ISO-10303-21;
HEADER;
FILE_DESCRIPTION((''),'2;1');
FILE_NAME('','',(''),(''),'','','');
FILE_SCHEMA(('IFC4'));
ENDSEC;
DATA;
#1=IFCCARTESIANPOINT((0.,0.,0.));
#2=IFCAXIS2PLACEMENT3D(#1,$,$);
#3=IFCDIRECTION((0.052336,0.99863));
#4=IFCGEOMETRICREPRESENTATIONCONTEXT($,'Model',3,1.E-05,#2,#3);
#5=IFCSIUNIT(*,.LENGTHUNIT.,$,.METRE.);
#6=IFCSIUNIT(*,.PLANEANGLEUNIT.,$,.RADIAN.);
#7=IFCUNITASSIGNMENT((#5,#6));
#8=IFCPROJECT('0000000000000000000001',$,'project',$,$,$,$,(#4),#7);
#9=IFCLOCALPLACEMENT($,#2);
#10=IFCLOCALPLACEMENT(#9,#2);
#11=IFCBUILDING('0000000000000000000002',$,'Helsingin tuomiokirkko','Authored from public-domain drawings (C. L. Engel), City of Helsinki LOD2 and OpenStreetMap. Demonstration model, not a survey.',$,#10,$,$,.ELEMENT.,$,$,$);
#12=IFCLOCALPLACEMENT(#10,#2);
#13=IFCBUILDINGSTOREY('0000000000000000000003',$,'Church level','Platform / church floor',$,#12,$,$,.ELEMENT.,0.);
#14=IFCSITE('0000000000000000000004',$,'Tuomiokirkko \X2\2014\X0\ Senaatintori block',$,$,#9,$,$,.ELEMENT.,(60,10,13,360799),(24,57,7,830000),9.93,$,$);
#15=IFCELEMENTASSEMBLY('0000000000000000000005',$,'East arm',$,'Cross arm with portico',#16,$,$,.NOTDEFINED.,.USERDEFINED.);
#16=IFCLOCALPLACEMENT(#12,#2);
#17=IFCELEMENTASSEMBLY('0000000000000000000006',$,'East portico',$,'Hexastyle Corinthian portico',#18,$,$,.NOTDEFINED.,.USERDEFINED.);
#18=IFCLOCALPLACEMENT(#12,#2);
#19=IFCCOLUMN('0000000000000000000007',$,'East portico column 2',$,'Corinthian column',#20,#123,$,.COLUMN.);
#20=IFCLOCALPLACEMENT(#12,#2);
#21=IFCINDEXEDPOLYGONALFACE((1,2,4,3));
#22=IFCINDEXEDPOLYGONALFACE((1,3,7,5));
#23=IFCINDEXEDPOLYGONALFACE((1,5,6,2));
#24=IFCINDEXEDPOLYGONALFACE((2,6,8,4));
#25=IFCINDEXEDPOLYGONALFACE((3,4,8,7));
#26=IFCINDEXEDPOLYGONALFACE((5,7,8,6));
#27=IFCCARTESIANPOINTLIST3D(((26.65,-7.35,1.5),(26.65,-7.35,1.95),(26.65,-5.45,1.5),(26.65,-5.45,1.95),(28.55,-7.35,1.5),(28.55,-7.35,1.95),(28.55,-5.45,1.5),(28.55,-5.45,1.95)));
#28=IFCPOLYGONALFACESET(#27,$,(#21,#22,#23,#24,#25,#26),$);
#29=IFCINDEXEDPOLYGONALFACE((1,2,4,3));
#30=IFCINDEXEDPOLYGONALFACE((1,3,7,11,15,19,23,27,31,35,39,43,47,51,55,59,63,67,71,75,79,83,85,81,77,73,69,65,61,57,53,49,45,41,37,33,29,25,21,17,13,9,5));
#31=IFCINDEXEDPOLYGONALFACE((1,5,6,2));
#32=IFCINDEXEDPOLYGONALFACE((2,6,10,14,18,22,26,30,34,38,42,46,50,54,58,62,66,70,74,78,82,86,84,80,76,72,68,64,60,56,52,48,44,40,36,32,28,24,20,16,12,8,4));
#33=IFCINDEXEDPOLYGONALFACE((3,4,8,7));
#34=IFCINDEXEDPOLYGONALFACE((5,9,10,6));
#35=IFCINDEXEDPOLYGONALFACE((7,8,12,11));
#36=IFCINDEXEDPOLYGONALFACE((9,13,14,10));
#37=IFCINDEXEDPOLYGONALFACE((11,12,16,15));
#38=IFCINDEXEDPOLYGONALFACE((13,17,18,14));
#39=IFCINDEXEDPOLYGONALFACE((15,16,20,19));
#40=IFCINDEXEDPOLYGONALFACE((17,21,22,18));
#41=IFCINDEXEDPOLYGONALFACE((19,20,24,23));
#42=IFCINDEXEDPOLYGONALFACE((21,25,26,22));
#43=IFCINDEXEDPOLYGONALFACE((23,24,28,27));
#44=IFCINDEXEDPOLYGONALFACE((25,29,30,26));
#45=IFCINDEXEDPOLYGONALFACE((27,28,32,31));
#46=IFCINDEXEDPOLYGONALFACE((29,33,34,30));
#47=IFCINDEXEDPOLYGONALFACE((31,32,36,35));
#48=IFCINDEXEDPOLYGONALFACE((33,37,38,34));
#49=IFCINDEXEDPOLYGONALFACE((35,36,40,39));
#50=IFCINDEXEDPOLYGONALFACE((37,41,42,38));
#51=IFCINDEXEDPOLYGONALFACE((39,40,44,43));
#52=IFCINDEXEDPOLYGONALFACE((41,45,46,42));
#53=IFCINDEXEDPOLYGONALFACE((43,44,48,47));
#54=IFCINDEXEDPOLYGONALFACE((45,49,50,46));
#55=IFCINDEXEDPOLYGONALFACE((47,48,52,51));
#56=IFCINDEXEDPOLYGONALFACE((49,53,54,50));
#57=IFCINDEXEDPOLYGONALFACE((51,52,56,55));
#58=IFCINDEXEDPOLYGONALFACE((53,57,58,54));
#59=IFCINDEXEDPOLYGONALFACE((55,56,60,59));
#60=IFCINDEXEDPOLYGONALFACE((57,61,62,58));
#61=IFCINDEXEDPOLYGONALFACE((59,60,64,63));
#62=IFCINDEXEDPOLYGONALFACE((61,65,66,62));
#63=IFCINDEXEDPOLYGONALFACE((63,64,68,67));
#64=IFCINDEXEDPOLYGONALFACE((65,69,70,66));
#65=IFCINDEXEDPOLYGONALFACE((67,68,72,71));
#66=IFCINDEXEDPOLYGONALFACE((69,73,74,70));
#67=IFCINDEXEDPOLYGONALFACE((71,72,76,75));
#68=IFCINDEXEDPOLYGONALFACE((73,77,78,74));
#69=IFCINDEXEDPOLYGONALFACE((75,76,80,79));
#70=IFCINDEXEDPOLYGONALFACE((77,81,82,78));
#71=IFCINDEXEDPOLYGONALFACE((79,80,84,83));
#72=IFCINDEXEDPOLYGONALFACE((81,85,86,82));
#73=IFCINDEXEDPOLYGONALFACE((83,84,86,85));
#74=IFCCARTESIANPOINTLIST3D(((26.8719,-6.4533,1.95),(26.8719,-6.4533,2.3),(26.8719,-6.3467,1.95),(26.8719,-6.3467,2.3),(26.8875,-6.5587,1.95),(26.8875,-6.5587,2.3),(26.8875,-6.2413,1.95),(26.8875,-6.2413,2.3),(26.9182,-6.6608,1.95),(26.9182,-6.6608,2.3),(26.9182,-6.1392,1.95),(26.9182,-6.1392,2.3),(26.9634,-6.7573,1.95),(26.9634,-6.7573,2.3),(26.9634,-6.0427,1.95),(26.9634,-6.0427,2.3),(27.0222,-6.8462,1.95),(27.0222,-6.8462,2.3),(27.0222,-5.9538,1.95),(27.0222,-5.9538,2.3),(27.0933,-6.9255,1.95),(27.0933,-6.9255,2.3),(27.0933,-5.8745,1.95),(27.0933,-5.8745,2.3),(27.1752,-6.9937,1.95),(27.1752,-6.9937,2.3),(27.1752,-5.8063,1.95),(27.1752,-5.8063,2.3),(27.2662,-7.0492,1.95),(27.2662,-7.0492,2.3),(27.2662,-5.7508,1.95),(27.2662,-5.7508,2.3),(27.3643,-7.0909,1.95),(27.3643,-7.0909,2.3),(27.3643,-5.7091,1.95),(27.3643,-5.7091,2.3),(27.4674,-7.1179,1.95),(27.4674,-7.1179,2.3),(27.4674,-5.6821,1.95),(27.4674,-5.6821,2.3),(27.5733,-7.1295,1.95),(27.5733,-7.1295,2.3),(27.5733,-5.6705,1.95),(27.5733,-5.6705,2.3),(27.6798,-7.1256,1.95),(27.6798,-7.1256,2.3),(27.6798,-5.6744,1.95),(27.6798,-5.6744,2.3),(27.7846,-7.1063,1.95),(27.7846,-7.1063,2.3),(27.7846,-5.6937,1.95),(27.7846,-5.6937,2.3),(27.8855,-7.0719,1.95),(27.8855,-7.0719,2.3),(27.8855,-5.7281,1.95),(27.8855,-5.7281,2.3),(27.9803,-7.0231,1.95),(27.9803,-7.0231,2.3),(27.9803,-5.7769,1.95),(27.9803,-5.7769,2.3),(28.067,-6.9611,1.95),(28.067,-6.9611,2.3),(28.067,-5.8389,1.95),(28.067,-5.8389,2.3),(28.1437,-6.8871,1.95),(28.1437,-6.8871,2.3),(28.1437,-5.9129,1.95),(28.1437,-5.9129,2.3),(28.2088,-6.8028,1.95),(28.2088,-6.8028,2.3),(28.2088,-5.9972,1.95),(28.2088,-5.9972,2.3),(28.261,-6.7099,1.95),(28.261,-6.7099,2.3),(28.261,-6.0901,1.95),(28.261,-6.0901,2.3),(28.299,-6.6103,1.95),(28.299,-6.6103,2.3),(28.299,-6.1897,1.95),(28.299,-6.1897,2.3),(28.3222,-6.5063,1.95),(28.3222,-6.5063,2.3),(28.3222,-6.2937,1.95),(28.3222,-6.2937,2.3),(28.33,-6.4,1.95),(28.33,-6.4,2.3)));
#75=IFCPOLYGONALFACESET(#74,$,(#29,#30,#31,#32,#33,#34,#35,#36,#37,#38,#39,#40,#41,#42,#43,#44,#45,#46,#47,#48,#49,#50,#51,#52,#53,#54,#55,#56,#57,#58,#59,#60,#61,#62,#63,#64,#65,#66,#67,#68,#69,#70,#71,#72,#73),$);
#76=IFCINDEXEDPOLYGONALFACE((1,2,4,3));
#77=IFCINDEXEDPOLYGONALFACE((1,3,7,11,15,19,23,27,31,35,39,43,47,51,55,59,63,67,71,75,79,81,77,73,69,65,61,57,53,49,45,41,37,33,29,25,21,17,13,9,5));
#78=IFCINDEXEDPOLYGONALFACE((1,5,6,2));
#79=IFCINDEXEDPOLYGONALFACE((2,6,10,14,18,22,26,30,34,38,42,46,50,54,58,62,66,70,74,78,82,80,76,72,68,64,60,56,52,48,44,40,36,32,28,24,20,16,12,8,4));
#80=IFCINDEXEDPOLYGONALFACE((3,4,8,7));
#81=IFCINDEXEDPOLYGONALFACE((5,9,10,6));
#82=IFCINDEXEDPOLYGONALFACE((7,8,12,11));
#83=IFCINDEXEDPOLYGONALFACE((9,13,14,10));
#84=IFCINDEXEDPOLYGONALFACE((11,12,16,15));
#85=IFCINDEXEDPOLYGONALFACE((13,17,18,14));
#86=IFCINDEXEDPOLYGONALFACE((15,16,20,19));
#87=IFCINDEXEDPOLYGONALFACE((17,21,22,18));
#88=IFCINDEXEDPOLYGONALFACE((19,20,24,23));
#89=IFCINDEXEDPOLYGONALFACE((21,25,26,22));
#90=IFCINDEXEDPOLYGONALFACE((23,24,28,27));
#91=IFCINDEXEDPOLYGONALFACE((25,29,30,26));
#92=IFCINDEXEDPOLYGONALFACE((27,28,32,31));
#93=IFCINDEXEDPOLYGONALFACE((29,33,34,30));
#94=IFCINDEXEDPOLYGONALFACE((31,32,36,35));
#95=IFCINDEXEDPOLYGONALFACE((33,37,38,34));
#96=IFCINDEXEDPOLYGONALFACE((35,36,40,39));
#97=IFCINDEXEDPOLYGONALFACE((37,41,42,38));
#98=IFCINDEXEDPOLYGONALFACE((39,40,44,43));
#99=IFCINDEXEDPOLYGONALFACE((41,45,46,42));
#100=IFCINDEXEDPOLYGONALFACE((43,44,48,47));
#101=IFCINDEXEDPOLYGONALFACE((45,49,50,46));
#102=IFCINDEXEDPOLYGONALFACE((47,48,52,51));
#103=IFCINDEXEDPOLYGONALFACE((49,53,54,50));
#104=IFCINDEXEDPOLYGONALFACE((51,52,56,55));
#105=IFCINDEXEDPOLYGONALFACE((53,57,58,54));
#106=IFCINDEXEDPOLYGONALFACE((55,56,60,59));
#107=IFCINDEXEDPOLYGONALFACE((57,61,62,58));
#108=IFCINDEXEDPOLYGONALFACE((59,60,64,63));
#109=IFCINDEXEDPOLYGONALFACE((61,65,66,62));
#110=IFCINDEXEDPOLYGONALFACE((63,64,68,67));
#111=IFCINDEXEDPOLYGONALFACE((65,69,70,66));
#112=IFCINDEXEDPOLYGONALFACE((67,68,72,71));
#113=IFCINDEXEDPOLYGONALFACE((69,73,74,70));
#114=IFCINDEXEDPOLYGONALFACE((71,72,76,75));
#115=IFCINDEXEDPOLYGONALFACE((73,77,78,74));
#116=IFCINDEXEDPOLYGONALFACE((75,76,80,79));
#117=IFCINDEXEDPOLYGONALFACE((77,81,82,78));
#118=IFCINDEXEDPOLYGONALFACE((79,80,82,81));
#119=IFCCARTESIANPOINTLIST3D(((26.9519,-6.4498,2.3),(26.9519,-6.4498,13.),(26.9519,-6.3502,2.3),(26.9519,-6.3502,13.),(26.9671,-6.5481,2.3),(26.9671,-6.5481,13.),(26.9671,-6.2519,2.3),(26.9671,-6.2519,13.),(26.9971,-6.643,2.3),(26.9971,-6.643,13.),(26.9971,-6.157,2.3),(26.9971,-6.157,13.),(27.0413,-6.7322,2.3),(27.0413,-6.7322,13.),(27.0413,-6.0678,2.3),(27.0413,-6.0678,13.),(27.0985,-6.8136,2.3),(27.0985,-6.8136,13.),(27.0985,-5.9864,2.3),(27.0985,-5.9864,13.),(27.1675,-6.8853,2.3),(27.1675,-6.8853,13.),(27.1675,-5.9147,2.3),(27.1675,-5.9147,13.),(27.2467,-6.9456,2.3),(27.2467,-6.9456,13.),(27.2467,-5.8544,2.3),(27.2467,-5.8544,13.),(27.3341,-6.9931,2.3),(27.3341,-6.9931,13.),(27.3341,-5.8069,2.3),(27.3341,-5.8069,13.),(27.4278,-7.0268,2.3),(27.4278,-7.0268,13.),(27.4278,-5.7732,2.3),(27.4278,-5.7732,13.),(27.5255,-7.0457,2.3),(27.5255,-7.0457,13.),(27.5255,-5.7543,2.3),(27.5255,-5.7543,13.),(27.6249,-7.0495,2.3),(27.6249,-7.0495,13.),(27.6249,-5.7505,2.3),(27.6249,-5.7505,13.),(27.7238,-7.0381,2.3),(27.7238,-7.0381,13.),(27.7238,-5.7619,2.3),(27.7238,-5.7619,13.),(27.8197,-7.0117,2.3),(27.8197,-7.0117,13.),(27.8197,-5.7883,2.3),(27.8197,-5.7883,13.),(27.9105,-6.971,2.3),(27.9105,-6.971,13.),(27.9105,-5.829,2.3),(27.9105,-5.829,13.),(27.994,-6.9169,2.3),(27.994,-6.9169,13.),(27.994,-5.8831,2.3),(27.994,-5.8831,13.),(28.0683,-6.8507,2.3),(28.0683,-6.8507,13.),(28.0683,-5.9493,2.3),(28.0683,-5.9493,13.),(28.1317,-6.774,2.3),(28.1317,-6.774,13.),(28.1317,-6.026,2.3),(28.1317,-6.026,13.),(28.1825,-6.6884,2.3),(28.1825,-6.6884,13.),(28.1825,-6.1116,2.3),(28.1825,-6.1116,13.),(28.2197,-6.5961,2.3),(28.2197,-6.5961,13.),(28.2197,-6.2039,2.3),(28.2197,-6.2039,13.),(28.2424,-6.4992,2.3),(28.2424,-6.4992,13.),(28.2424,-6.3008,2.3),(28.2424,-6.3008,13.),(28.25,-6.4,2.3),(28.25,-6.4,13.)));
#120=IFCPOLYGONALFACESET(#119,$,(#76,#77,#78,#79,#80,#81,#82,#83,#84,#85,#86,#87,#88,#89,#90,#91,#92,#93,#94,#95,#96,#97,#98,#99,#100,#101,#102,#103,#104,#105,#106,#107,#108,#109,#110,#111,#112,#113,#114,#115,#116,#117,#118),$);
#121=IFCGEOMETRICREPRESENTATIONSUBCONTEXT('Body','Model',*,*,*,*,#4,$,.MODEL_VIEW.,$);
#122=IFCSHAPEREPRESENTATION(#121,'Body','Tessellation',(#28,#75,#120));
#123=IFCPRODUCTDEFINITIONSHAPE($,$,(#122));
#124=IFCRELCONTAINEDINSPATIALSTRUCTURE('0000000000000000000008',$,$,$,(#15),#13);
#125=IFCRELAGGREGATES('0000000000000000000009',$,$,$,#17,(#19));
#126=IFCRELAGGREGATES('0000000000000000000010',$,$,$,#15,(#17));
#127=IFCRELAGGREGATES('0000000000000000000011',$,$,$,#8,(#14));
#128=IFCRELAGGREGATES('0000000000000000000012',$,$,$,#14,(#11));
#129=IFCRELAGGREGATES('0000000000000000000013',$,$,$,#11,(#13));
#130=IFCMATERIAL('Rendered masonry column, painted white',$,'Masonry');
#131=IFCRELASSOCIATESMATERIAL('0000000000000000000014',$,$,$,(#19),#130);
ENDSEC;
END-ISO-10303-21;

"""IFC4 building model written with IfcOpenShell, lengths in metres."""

from ifc_helpers import new_model, si_unit, direction, frame, origin, origin_2d_with_axis, place, context, subcontext, project, spatial, rectangle, circle, extrude, material, element, aggregate, save


model = new_model("IFC4")

# Units and contexts
model_context = context("Model", 3, precision=1e-05, world=origin(), true_north=direction((0.052336, 0.99863)))
body_context = subcontext(model_context, "Body", "Model", "MODEL_VIEW")
ifc_project = project(units=[si_unit("LENGTHUNIT", "METRE"), si_unit("PLANEANGLEUNIT", "RADIAN")], contexts=[model_context])

# Site, building, storey
site_placement = place(None, origin())
site = spatial("IfcSite", under=ifc_project, at=site_placement, Name="Tuomiokirkko — Senaatintori block", CompositionType="ELEMENT", RefLatitude=(60, 10, 13, 360799), RefLongitude=(24, 57, 7, 830000), RefElevation=9.93)
building_placement = place(site_placement, origin())
building = spatial("IfcBuilding", under=site, at=building_placement, Name="Helsingin tuomiokirkko", Description="Authored from public-domain drawings (C. L. Engel), City of Helsinki LOD2 and OpenStreetMap. Demonstration model, not a survey.", CompositionType="ELEMENT")
storey_placement = place(building_placement, origin())
storey = spatial("IfcBuildingStorey", under=building, at=storey_placement, Name="Church level", Description="Platform / church floor", CompositionType="ELEMENT", Elevation=0.0)

# Shared definitions
ifc_material_1 = material(Name="Rendered masonry column, painted white", Category="Masonry")

# Element assemblies, column
assembly_1_placement = place(building_placement, origin())
assembly_1 = element("IfcElementAssembly", 1, at=assembly_1_placement, inside=storey, Name="East arm", ObjectType="Cross arm with portico", AssemblyPlace="NOTDEFINED", PredefinedType="USERDEFINED")
assembly_2_placement = place(building_placement, origin())
assembly_2 = element("IfcElementAssembly", 2, at=assembly_2_placement, Name="East portico", ObjectType="Hexastyle Corinthian portico", AssemblyPlace="NOTDEFINED", PredefinedType="USERDEFINED")
column_1_placement = place(building_placement, origin())
column_1 = element("IfcColumn", 3, at=column_1_placement, material=ifc_material_1, Name="East portico column 2", ObjectType="Corinthian column", PredefinedType="COLUMN", context=body_context, shape_type="SweptSolid", body=[
    extrude(rectangle(XDim=1.9, YDim=1.9, at=origin_2d_with_axis()), frame((27.6, -6.4, 1.5)), (0.0, 0.0, 1.0), 0.45),
    extrude(circle(Radius=0.73, at=origin_2d_with_axis()), frame((27.6, -6.4, 1.95)), (0.0, 0.0, 1.0), 0.35),
    extrude(circle(Radius=0.65, at=origin_2d_with_axis()), frame((27.6, -6.4, 2.3)), (0.0, 0.0, 1.0), 10.7),
])

aggregate(assembly_2, [column_1])

aggregate(assembly_1, [assembly_2])

save(model, "model.ifc")
